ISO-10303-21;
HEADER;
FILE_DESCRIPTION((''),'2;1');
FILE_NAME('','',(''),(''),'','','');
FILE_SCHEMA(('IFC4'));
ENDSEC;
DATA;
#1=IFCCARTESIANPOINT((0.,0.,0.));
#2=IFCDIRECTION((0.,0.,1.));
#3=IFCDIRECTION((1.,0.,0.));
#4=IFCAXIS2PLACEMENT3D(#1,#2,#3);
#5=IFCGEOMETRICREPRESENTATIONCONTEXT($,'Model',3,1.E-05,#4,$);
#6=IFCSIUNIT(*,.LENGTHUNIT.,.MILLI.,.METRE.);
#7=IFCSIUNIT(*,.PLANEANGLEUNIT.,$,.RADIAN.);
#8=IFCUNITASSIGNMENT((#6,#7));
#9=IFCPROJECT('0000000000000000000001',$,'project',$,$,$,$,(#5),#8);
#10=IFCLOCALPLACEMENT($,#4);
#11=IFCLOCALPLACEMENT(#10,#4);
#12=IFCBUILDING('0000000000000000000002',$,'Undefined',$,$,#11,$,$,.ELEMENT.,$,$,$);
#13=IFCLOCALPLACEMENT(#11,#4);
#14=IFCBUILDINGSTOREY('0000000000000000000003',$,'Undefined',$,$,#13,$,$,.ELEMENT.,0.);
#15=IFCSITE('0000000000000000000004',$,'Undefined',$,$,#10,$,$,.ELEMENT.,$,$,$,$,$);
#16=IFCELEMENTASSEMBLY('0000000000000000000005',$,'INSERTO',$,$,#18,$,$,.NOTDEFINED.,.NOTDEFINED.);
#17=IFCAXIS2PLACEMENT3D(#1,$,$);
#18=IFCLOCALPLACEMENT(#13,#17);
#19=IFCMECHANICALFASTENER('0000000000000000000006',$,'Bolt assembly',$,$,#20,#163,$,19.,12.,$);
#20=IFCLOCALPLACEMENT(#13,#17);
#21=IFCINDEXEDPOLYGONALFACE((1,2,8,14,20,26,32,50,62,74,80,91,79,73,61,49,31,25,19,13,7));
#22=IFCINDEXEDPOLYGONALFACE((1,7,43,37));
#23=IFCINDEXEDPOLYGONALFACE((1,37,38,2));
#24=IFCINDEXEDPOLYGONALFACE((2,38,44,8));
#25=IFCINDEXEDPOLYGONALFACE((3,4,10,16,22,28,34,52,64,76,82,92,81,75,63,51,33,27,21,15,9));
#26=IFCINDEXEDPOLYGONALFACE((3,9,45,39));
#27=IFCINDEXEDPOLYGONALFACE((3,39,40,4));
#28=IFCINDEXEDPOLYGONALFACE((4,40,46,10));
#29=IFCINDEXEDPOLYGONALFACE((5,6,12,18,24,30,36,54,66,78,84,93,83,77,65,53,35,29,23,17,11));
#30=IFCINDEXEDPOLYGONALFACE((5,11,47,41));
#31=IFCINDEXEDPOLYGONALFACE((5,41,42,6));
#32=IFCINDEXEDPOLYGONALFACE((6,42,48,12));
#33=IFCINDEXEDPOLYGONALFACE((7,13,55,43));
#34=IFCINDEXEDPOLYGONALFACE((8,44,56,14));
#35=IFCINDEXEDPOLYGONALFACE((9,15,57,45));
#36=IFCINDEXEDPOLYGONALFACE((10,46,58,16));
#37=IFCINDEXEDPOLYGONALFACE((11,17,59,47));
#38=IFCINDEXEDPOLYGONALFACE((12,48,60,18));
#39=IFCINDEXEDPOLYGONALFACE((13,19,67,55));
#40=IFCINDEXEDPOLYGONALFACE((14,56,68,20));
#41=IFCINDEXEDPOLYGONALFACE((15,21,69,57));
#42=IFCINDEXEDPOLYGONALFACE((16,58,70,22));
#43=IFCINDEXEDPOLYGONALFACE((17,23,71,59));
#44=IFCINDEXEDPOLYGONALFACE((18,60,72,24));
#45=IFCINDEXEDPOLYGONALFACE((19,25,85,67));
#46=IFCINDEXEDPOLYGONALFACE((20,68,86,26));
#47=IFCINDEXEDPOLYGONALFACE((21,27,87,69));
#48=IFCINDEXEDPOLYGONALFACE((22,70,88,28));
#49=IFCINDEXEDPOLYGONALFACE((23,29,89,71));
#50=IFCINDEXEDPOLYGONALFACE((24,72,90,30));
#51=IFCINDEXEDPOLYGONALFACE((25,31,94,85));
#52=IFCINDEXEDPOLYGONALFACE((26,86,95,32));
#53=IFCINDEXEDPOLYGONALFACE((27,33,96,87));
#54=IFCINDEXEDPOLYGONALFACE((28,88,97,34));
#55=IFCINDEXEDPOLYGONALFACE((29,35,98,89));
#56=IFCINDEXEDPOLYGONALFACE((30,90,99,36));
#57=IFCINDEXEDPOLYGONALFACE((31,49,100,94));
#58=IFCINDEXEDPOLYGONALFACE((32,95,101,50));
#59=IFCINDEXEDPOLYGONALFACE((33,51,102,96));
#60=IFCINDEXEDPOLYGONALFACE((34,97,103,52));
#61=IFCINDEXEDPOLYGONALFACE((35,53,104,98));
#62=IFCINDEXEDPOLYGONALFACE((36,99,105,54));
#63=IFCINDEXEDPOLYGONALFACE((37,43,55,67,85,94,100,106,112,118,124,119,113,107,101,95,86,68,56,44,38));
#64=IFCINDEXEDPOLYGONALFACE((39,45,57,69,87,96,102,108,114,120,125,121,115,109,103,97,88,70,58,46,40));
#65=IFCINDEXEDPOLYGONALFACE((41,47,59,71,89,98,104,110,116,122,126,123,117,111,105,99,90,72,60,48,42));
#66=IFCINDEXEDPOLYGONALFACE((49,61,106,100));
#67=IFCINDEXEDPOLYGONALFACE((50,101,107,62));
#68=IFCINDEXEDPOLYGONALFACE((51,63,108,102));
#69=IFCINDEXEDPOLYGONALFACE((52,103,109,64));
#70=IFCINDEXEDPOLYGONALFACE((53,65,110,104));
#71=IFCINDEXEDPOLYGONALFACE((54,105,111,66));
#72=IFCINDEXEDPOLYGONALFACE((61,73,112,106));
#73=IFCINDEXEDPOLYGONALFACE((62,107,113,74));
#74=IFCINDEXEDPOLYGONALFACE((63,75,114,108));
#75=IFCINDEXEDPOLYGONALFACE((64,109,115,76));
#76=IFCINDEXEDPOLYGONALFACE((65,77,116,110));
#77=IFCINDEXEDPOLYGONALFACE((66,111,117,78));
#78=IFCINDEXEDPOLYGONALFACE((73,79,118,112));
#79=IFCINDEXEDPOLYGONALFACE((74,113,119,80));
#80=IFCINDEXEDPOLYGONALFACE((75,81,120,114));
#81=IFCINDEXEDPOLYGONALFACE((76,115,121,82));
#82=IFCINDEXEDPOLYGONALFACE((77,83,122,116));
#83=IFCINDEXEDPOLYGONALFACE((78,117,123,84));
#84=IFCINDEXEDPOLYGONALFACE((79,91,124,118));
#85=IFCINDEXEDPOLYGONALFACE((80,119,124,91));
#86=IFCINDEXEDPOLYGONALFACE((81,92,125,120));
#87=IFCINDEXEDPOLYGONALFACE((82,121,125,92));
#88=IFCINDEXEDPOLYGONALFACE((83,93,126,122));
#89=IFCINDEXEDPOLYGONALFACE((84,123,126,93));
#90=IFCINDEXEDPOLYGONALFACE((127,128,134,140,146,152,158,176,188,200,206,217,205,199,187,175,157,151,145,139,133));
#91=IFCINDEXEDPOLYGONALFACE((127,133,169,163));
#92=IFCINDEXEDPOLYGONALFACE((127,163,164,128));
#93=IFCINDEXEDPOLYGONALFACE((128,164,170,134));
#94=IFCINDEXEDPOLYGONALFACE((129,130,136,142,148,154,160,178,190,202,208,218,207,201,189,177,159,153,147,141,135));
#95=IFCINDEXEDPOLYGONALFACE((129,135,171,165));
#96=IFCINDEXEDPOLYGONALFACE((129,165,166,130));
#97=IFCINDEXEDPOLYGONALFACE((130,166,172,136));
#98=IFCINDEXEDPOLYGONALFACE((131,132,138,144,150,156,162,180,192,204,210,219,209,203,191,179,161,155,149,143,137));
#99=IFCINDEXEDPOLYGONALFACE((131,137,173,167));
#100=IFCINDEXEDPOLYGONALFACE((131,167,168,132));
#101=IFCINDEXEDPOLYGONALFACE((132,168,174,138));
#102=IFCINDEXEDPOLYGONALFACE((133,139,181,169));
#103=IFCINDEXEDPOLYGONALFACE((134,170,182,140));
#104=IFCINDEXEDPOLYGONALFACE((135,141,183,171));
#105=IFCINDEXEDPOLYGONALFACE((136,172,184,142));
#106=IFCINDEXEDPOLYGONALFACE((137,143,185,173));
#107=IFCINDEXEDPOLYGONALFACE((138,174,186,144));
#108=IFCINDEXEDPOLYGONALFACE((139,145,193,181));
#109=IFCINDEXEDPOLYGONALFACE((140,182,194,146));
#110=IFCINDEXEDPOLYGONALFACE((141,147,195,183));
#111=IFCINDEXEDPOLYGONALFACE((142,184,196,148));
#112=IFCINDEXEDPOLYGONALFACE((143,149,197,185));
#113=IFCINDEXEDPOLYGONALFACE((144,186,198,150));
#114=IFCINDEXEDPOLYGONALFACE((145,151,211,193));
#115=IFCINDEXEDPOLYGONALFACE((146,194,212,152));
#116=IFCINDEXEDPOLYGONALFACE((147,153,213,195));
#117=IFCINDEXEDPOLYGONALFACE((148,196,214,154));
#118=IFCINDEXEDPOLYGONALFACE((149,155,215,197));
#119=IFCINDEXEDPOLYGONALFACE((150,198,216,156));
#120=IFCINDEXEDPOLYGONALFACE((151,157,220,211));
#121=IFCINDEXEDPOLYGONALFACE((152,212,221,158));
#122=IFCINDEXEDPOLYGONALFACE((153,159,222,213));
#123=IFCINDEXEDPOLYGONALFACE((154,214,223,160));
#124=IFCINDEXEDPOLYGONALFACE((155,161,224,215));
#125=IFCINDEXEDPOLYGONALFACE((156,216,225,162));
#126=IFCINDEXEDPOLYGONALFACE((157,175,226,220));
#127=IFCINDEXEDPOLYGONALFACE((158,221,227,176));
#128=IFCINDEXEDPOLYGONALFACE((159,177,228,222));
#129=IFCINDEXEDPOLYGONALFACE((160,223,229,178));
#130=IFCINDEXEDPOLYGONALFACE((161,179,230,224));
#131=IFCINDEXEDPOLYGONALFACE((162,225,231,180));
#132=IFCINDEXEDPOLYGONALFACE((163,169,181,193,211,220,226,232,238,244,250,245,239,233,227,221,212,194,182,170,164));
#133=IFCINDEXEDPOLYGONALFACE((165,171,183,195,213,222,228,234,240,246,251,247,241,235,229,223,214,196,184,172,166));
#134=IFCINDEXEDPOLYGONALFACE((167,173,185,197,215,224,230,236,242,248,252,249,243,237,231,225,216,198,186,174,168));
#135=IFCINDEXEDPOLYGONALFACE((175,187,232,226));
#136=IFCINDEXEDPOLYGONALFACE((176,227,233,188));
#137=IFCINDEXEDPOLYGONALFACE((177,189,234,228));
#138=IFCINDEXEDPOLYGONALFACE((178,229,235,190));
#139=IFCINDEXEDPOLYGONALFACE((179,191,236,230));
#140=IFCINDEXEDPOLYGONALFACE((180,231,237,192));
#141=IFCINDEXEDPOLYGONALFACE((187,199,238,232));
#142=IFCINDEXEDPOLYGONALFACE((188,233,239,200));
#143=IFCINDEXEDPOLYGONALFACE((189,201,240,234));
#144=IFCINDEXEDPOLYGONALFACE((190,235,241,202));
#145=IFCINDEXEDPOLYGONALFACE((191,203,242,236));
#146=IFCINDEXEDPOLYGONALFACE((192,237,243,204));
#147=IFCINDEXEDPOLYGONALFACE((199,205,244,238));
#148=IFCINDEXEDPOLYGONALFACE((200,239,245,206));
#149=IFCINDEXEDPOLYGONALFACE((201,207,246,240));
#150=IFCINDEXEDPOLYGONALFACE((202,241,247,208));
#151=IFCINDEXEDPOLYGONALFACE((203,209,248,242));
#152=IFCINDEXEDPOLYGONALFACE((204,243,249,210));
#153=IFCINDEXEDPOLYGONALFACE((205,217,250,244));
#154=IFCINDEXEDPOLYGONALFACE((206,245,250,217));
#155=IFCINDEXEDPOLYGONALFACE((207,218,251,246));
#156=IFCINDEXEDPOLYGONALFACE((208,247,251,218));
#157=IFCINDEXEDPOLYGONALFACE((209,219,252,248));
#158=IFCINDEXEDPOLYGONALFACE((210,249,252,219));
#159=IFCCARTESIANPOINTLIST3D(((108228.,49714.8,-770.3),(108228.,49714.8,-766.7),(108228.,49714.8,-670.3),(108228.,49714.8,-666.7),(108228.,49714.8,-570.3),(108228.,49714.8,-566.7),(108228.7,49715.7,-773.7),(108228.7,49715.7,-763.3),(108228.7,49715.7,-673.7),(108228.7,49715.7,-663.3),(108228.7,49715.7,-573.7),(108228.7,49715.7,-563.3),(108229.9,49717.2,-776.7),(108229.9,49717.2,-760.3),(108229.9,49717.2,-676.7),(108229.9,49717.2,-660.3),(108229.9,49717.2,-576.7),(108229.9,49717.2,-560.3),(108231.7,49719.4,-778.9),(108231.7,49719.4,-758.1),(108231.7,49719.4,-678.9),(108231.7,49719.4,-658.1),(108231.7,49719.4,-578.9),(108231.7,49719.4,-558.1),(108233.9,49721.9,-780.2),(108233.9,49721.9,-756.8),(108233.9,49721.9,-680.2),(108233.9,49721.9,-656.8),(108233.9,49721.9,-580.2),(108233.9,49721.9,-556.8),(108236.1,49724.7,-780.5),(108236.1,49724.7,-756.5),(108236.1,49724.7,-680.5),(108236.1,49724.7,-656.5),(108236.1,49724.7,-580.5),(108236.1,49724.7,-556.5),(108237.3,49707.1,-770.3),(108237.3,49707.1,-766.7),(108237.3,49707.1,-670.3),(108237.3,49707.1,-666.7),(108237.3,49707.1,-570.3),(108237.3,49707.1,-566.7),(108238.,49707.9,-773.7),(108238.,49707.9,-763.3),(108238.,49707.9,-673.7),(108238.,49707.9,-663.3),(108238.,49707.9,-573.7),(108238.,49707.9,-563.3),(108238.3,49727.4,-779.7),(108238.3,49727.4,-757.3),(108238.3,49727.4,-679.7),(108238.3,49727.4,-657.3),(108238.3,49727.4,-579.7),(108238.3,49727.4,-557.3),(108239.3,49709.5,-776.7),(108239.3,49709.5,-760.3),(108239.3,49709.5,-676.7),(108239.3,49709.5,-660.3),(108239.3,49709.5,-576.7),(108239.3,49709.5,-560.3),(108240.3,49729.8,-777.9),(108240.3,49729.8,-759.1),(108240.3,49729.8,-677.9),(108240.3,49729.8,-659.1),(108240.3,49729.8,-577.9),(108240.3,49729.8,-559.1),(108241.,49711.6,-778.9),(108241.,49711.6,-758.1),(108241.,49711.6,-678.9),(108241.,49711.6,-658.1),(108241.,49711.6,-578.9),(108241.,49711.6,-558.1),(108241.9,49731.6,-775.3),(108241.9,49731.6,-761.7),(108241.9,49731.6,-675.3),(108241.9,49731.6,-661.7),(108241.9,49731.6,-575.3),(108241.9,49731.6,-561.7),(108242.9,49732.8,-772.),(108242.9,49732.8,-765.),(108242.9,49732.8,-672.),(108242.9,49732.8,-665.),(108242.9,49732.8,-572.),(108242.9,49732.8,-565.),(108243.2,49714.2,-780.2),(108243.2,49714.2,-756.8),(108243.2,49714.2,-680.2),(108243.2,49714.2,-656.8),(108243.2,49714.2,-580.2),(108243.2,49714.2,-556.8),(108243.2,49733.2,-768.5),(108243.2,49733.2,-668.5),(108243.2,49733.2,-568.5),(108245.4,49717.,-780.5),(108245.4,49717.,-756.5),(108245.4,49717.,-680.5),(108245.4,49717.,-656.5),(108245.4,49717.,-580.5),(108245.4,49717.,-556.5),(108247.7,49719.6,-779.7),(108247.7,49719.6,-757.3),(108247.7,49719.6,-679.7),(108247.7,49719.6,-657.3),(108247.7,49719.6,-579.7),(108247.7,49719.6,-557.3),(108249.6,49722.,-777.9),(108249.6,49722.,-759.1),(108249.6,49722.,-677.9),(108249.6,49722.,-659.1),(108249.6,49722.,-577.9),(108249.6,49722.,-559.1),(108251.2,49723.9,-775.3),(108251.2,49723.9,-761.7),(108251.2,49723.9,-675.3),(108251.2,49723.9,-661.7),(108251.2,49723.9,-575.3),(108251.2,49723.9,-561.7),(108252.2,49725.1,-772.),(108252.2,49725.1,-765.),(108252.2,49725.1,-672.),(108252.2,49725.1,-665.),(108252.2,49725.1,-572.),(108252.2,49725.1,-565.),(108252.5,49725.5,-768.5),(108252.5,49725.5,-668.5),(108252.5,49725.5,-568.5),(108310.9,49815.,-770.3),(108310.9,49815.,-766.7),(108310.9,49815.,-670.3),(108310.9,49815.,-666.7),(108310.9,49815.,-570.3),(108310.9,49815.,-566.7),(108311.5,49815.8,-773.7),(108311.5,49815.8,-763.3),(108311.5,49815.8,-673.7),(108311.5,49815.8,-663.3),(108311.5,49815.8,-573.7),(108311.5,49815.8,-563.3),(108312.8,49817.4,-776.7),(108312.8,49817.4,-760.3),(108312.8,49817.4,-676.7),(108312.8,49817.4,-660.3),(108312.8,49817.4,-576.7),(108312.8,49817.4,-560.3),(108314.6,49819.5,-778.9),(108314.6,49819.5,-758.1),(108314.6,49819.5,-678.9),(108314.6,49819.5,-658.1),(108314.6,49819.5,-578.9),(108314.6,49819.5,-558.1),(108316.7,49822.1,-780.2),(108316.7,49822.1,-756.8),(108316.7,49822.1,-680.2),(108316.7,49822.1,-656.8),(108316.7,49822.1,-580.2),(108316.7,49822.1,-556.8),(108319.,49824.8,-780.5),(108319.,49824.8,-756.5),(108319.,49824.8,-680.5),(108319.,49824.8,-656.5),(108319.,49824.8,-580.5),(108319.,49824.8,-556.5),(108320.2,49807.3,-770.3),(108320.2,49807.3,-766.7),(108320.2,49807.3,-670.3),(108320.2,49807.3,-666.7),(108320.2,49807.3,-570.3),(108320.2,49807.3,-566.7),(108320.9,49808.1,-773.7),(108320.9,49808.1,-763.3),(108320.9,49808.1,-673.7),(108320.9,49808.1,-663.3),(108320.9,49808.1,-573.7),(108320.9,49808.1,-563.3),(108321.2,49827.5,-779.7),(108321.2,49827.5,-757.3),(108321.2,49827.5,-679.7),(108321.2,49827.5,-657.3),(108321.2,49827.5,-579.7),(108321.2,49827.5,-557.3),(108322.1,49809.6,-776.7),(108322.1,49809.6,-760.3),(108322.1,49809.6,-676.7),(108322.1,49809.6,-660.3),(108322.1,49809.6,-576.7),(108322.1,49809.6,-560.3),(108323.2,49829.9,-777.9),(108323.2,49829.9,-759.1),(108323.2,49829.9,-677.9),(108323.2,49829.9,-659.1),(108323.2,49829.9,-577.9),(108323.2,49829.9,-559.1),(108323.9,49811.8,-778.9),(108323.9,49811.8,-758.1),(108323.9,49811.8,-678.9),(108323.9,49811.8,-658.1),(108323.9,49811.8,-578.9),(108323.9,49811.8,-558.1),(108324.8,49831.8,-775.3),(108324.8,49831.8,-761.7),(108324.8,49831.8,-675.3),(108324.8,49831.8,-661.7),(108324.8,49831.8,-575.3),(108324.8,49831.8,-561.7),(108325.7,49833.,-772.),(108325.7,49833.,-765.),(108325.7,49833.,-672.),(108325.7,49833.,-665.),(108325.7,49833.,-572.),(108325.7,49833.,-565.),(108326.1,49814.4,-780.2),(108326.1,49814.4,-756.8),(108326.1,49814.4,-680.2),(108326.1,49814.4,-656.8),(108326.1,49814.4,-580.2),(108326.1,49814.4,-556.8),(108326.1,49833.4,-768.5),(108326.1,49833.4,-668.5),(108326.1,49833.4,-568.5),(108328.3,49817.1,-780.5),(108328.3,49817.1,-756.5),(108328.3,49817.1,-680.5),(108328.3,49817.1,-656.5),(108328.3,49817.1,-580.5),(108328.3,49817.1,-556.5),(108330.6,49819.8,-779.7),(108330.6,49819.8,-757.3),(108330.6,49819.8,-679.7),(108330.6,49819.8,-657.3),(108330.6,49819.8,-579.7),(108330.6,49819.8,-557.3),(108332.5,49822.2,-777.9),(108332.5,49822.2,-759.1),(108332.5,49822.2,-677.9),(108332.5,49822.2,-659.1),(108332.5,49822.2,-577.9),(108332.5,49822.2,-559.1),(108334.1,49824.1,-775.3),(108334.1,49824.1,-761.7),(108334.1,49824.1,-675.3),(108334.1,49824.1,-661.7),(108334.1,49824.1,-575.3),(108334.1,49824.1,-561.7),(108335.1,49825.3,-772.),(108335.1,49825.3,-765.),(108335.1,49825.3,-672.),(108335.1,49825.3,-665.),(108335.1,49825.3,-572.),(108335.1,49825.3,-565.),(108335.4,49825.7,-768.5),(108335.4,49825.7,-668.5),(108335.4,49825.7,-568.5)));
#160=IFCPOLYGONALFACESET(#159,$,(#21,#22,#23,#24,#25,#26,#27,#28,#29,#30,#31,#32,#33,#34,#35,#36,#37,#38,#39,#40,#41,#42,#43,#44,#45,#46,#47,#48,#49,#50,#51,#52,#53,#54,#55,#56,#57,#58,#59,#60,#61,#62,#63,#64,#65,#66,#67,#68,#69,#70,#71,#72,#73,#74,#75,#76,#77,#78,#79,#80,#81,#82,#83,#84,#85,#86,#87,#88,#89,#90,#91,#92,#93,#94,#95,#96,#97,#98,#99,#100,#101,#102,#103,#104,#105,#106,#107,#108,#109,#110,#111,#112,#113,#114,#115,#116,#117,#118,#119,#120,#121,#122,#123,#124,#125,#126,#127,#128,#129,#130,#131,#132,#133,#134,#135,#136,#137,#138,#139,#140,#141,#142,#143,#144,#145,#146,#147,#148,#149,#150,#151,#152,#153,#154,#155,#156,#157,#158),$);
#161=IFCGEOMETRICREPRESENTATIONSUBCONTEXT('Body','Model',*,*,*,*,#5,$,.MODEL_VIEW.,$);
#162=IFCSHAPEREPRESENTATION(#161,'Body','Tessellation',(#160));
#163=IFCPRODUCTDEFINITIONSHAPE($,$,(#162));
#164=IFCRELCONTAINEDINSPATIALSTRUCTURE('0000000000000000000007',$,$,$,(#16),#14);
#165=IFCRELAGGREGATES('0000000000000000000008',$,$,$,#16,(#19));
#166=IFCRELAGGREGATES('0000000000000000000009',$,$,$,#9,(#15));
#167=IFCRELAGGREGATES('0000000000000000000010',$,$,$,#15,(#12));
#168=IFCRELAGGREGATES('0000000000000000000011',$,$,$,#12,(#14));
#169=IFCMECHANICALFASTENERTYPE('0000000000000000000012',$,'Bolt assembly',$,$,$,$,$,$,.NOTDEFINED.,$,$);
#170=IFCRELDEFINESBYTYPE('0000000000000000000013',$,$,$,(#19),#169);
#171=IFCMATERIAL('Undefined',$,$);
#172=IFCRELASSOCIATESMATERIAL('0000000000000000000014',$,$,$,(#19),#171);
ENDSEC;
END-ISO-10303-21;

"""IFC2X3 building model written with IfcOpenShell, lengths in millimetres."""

from ifc_helpers import new_model, si_unit, frame, origin_with_axes, origin_2d_with_axis, place, context, subcontext, project, spatial, circle, extrude, source, transform, mapped, material, type_object, element, aggregate, save


model = new_model("IFC2X3")

# Units and contexts
model_context = context("Model", 3, precision=1e-05, world=origin_with_axes())
body_context = subcontext(model_context, "Body", "Model", "MODEL_VIEW")
ifc_project = project(units=[si_unit("LENGTHUNIT", "METRE", prefix="MILLI"), si_unit("PLANEANGLEUNIT", "RADIAN")], contexts=[model_context])

# Site, building, storey
site_placement = place(None, origin_with_axes())
site = spatial("IfcSite", under=ifc_project, at=site_placement, Name="Undefined", CompositionType="ELEMENT")
building_placement = place(site_placement, origin_with_axes())
building = spatial("IfcBuilding", under=site, at=building_placement, Name="Undefined", CompositionType="ELEMENT")
storey_placement = place(building_placement, origin_with_axes())
storey = spatial("IfcBuildingStorey", under=building, at=storey_placement, Name="Undefined", CompositionType="ELEMENT", Elevation=0.0)

# Element assembly
assembly_1_placement = place(storey_placement, origin_with_axes())
assembly_1 = element("IfcElementAssembly", 1, at=assembly_1_placement, inside=storey, Name="INSERTO", AssemblyPlace="NOTDEFINED", PredefinedType="NOTDEFINED")

# Mechanical fastener
ifc_material_1 = material(Name="Undefined")
mechanical_fastener_type = type_object("IfcMechanicalFastenerType", Name="Bolt assembly")
shared_shape_1 = source(origin_with_axes(), body_context, "Body", "SweptSolid", [
    extrude(circle(Radius=12.0, at=origin_2d_with_axis()), frame((0.0, 0.0, 0.0), z_axis=(0.0, 1.0, 0.0), x_axis=(1.0, 0.0, 0.0)), (0.0, 0.0, 1.0), 12.1),
])
mechanical_fastener_1_placement = place(assembly_1_placement, frame((108244.9, 49716.3, -668.5), z_axis=(0.000001, 0.000001, 1.0), x_axis=(0.637563, 0.770399, -0.000002)))
mechanical_fastener_1 = element("IfcMechanicalFastener", 2, at=mechanical_fastener_1_placement, type_object=mechanical_fastener_type, material=ifc_material_1, Name="Bolt assembly", NominalDiameter=19.0, NominalLength=12.0, context=body_context, shape_type="MappedRepresentation", body=[
    mapped(shared_shape_1, transform((0.0, 0.0, -100.0))),
    mapped(shared_shape_1, transform((130.0, 0.0, -100.0))),
    mapped(shared_shape_1, transform((0.0, 0.0, 0.0))),
    mapped(shared_shape_1, transform((130.0, 0.0, 0.0))),
    mapped(shared_shape_1, transform((0.0, 0.0, 100.0))),
    mapped(shared_shape_1, transform((130.0, 0.0, 100.0))),
])
aggregate(assembly_1, [mechanical_fastener_1])

save(model, "model.ifc")
